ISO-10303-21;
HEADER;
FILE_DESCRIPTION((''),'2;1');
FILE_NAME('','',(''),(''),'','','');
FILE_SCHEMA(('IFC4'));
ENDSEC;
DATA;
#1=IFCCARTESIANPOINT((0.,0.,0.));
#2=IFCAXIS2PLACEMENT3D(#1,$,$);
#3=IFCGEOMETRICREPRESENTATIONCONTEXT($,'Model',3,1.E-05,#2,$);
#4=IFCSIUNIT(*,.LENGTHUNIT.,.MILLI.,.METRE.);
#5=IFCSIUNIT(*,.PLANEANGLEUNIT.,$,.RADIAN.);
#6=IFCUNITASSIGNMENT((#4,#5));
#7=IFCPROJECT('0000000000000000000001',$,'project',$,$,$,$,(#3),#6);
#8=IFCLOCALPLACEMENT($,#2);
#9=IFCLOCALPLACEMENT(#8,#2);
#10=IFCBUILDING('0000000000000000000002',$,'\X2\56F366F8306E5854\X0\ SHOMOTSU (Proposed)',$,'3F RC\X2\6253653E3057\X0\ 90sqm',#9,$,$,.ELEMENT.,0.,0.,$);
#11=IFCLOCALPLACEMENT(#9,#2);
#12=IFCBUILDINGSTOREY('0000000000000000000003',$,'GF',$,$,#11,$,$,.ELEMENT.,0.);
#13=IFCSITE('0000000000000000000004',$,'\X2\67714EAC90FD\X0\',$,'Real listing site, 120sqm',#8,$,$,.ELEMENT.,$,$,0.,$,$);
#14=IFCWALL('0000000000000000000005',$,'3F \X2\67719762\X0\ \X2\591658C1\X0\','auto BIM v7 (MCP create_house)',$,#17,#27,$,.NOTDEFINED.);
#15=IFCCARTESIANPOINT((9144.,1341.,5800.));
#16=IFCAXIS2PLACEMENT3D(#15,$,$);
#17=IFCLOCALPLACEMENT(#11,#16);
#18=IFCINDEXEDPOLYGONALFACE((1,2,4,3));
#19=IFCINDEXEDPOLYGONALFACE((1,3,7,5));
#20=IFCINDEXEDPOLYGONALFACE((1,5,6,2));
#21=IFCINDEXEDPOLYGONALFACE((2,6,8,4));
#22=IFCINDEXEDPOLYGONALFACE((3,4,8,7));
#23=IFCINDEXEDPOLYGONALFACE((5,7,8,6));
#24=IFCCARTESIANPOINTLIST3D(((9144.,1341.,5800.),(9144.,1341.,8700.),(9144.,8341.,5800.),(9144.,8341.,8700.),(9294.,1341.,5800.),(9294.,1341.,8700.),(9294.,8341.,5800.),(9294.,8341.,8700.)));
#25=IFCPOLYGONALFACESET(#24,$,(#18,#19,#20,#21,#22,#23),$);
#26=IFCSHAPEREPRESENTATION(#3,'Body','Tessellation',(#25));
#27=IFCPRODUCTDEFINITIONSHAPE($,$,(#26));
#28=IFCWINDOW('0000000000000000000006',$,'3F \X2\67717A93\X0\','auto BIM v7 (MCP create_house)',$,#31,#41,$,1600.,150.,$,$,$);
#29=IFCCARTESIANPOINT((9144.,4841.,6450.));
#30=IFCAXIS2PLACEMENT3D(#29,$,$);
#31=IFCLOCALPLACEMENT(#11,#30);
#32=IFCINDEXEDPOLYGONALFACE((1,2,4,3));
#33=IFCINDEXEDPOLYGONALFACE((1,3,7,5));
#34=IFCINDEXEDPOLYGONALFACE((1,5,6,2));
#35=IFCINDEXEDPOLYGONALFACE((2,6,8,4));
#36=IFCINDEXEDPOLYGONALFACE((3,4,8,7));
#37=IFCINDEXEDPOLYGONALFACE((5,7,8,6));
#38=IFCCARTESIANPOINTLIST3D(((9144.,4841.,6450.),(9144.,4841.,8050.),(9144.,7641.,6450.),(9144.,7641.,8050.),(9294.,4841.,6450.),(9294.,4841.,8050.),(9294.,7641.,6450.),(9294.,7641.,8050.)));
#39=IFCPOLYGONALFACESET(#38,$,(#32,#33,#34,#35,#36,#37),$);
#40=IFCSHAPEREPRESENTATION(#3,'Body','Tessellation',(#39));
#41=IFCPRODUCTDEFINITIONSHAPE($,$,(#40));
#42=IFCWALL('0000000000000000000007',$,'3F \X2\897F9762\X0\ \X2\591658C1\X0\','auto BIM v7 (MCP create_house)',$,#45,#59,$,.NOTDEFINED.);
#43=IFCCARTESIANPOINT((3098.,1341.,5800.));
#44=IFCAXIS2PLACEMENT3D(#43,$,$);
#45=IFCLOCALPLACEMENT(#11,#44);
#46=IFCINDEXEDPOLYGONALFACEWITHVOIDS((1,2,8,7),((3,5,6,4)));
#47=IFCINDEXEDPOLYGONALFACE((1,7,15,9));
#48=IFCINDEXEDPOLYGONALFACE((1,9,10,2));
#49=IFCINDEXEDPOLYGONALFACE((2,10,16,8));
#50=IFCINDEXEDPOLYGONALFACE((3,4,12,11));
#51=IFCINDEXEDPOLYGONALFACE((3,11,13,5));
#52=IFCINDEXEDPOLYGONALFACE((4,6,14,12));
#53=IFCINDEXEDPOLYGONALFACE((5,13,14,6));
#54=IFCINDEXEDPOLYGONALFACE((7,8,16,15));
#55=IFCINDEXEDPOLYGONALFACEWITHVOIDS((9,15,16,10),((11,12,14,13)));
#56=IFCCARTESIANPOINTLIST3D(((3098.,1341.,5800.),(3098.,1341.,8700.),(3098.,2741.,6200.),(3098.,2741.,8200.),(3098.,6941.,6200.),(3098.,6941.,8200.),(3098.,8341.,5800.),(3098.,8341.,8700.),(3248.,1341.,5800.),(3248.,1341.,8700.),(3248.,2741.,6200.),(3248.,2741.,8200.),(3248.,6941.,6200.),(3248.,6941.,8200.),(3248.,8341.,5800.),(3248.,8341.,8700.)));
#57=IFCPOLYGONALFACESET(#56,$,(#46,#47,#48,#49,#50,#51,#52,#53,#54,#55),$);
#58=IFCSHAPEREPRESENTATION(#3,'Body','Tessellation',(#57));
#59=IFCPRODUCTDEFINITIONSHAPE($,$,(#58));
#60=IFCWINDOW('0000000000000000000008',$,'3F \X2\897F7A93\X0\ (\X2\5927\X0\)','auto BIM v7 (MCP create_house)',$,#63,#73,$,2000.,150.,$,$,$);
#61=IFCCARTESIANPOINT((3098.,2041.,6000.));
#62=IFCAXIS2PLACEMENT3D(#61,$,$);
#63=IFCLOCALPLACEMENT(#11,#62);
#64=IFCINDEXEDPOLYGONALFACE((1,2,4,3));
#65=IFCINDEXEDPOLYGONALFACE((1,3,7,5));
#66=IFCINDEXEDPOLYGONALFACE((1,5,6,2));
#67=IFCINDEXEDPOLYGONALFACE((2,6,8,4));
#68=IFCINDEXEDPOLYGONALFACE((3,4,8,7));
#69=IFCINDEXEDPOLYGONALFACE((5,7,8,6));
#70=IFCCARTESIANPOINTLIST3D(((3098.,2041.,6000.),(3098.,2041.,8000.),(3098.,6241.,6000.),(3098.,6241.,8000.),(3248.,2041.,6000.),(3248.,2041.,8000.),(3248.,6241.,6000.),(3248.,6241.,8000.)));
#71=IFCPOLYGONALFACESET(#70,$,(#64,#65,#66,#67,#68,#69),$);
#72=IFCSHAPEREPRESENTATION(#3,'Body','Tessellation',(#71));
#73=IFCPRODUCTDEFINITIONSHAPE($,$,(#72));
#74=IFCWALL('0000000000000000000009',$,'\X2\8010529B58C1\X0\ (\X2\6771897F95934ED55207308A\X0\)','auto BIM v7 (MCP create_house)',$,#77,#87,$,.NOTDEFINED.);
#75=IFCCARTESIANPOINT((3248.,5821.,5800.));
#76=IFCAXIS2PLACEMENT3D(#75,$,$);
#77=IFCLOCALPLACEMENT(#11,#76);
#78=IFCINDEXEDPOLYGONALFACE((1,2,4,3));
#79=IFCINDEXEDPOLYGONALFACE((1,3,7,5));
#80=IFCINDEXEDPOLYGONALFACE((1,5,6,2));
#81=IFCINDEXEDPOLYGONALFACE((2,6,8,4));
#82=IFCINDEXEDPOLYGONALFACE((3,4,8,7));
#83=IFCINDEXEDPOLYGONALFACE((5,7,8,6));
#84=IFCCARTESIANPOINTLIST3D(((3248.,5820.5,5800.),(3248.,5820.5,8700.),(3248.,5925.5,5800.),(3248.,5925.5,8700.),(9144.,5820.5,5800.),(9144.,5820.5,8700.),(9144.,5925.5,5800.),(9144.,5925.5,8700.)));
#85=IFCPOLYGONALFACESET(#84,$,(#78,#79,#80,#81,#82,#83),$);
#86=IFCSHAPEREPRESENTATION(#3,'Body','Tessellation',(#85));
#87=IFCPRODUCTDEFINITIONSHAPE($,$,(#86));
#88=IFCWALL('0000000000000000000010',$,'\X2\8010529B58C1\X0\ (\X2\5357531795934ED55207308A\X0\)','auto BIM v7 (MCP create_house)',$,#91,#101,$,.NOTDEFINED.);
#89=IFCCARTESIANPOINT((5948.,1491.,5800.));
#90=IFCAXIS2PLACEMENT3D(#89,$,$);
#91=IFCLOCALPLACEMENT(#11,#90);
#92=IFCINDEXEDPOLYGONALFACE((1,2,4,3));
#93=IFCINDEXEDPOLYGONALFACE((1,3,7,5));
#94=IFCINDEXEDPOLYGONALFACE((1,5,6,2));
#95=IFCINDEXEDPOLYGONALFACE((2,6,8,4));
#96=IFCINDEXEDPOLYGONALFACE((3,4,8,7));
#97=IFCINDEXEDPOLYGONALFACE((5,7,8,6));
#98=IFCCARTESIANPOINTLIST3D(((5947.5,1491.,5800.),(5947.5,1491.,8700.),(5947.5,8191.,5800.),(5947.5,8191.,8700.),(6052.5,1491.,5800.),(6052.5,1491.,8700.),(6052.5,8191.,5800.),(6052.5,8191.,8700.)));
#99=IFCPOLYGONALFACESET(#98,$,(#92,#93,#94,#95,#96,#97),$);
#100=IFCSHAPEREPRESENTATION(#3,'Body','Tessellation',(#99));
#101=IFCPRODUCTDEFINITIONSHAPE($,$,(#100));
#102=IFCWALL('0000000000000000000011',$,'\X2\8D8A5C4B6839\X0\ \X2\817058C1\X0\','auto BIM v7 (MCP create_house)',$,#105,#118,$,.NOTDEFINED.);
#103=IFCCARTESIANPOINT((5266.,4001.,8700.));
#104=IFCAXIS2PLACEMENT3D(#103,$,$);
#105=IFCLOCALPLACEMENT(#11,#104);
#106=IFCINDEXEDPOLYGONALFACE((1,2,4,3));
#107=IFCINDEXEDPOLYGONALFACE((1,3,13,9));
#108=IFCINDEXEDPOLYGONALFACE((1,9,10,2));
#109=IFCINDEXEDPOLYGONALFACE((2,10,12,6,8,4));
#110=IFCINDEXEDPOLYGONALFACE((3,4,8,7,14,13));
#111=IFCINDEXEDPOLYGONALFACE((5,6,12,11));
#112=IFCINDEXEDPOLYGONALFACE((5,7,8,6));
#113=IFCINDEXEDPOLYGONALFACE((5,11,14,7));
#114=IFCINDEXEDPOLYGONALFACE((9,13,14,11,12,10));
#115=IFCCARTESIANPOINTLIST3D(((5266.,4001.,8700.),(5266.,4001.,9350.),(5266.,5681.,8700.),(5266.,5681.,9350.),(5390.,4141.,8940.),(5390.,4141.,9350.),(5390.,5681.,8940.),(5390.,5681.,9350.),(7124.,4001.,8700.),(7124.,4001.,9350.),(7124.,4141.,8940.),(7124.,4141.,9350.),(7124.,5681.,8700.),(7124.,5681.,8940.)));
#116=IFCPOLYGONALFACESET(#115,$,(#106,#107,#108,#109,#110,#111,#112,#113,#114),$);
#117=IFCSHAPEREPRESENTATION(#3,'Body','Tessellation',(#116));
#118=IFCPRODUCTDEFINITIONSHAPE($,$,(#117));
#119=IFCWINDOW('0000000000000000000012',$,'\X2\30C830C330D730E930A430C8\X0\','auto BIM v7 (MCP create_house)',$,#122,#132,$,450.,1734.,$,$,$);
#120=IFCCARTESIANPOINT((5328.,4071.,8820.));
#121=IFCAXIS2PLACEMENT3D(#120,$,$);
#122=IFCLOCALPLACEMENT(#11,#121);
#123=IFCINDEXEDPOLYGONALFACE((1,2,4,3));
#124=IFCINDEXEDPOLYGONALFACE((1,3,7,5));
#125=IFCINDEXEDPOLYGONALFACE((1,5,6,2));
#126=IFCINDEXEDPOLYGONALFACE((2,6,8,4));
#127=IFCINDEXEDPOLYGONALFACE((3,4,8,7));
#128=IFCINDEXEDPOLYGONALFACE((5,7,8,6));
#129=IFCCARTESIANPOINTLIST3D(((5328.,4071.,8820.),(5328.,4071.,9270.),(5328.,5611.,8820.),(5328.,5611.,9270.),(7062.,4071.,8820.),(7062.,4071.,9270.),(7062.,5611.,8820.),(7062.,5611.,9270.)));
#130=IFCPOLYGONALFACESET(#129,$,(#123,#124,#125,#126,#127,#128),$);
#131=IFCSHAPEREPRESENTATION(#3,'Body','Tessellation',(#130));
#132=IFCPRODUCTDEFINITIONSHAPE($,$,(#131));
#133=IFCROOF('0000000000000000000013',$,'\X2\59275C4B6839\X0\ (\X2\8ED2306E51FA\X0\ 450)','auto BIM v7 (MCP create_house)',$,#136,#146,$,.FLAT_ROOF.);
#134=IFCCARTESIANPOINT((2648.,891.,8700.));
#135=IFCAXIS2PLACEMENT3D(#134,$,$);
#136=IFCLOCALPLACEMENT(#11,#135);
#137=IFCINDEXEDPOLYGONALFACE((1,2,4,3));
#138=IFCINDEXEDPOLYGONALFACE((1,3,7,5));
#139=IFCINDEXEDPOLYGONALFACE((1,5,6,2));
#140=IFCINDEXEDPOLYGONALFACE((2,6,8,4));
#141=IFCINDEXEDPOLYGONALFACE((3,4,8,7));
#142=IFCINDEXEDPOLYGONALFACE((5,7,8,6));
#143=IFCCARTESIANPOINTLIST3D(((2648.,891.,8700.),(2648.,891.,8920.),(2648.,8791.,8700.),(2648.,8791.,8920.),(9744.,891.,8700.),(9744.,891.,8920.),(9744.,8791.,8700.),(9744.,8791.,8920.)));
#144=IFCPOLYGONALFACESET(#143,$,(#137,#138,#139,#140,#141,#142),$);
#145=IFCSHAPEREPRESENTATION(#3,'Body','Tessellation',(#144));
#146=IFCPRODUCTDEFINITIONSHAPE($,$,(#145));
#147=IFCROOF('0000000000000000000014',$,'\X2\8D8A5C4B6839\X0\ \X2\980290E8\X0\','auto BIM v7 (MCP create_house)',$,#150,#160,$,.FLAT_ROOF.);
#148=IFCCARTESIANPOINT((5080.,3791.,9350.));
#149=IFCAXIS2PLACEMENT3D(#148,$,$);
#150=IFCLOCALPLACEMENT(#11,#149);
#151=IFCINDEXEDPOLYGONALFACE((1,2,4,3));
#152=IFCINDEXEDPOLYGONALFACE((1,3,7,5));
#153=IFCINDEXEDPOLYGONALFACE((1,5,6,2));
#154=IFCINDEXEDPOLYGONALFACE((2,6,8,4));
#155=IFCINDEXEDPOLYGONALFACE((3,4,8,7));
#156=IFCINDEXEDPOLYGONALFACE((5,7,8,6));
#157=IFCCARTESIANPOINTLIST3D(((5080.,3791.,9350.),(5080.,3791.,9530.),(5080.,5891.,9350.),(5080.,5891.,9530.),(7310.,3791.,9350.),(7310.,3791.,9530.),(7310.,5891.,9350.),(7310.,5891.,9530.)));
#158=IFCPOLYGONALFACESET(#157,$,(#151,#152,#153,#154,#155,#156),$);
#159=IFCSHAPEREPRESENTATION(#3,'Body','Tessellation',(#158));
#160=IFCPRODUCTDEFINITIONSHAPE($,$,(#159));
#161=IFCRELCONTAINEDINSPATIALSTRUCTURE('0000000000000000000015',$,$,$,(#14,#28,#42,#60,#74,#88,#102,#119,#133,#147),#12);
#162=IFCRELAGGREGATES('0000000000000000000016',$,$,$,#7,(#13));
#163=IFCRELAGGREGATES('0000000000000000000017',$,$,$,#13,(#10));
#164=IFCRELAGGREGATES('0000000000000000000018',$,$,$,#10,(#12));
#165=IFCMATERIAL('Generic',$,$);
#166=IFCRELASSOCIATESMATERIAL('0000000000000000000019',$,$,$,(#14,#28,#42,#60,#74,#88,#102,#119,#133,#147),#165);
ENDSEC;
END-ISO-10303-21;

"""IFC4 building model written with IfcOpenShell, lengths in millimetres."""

from ifc_helpers import new_model, si_unit, frame, frame_2d, origin, place, context, project, spatial, rectangle, extrude, material, element, fill, save


model = new_model("IFC4")

# Units and contexts
model_context = context("Model", 3, precision=1e-05, world=origin())
ifc_project = project(units=[si_unit("LENGTHUNIT", "METRE", prefix="MILLI"), si_unit("PLANEANGLEUNIT", "RADIAN")], contexts=[model_context])

# Site, building, storey
site_placement = place(None, origin())
site = spatial("IfcSite", under=ifc_project, at=site_placement, Name="東京都", ObjectType="Real listing site, 120sqm", CompositionType="ELEMENT", RefElevation=0.0)
building_placement = place(site_placement, origin())
building = spatial("IfcBuilding", under=site, at=building_placement, Name="図書の塔 SHOMOTSU (Proposed)", ObjectType="3F RC打放し 90sqm", CompositionType="ELEMENT", ElevationOfRefHeight=0.0, ElevationOfTerrain=0.0)
storey_placement = place(building_placement, origin())
storey = spatial("IfcBuildingStorey", under=building, at=storey_placement, Name="GF", CompositionType="ELEMENT", Elevation=0.0)

# Shared definitions
ifc_material = material(Name="Generic")

# Walls, openings, windows
wall_1_placement = place(storey_placement, frame((9144.0, 1341.0, 5800.0)))
wall_1 = element("IfcWall", 1, at=wall_1_placement, inside=storey, material=ifc_material, Name="3F 東面 外壁", Description="auto BIM v7 (MCP create_house)", PredefinedType="NOTDEFINED", context=model_context, shape_type="SweptSolid", body=[
    extrude(rectangle(XDim=150.0, YDim=7000.0, at=frame_2d((75.0, 3500.0))), frame((9144.0, 1341.0, 5800.0)), (0.0, 0.0, 1.0), 2900.0),
])
opening_1_placement = place(storey_placement, frame((9144.0, 4841.0, 6450.0)))
opening_1 = element("IfcOpeningElement", 2, at=opening_1_placement, cuts=wall_1, PredefinedType="NOTDEFINED", context=model_context, shape_type="SweptSolid", body=[
    extrude(rectangle(XDim=150.0, YDim=2800.0, at=frame_2d((75.0, 1400.0))), frame((9144.0, 4841.0, 6450.0)), (0.0, 0.0, 1.0), 1600.0),
])
window_1_placement = place(storey_placement, frame((9144.0, 4841.0, 6450.0)))
window_1 = element("IfcWindow", 3, at=window_1_placement, inside=storey, material=ifc_material, Name="3F 東窓", Description="auto BIM v7 (MCP create_house)", OverallHeight=1600.0, OverallWidth=150.0, context=model_context, shape_type="SweptSolid", body=[
    extrude(rectangle(XDim=150.0, YDim=2800.0, at=frame_2d((75.0, 1400.0))), frame((9144.0, 4841.0, 6450.0)), (0.0, 0.0, 1.0), 1600.0),
])
fill(opening_1, window_1)
wall_2_placement = place(storey_placement, frame((3098.0, 1341.0, 5800.0)))
wall_2 = element("IfcWall", 4, at=wall_2_placement, inside=storey, material=ifc_material, Name="3F 西面 外壁", Description="auto BIM v7 (MCP create_house)", PredefinedType="NOTDEFINED", context=model_context, shape_type="SweptSolid", body=[
    extrude(rectangle(XDim=150.0, YDim=7000.0, at=frame_2d((75.0, 3500.0))), frame((3098.0, 1341.0, 5800.0)), (0.0, 0.0, 1.0), 2900.0),
])
opening_2_placement = place(storey_placement, frame((3098.0, 2041.0, 6000.0)))
opening_2 = element("IfcOpeningElement", 5, at=opening_2_placement, cuts=wall_2, PredefinedType="NOTDEFINED", context=model_context, shape_type="SweptSolid", body=[
    extrude(rectangle(XDim=150.0, YDim=4200.0, at=frame_2d((75.0, 2100.0))), frame((3098.0, 2041.0, 6000.0)), (0.0, 0.0, 1.0), 2000.0),
])
window_2_placement = place(storey_placement, frame((3098.0, 2041.0, 6000.0)))
window_2 = element("IfcWindow", 6, at=window_2_placement, inside=storey, material=ifc_material, Name="3F 西窓 (大)", Description="auto BIM v7 (MCP create_house)", OverallHeight=2000.0, OverallWidth=150.0, context=model_context, shape_type="SweptSolid", body=[
    extrude(rectangle(XDim=150.0, YDim=4200.0, at=frame_2d((75.0, 2100.0))), frame((3098.0, 2041.0, 6000.0)), (0.0, 0.0, 1.0), 2000.0),
])
fill(opening_2, window_2)

# Walls
wall_3_placement = place(storey_placement, frame((3248.0, 5821.0, 5800.0)))
element("IfcWall", 7, at=wall_3_placement, inside=storey, material=ifc_material, Name="耐力壁 (東西間仕切り)", Description="auto BIM v7 (MCP create_house)", PredefinedType="NOTDEFINED", context=model_context, shape_type="SweptSolid", body=[
    extrude(rectangle(XDim=5896.0, YDim=105.0, at=frame_2d((2948.0, 52.0))), frame((3248.0, 5821.0, 5800.0)), (0.0, 0.0, 1.0), 2900.0),
])
wall_4_placement = place(storey_placement, frame((5948.0, 1491.0, 5800.0)))
element("IfcWall", 8, at=wall_4_placement, inside=storey, material=ifc_material, Name="耐力壁 (南北間仕切り)", Description="auto BIM v7 (MCP create_house)", PredefinedType="NOTDEFINED", context=model_context, shape_type="SweptSolid", body=[
    extrude(rectangle(XDim=105.0, YDim=6700.0, at=frame_2d((52.0, 3350.0))), frame((5948.0, 1491.0, 5800.0)), (0.0, 0.0, 1.0), 2900.0),
])

# Wall, opening, window
wall_5_placement = place(storey_placement, frame((5266.0, 4001.0, 8700.0)))
wall_5 = element("IfcWall", 9, at=wall_5_placement, inside=storey, material=ifc_material, Name="越屋根 腰壁", Description="auto BIM v7 (MCP create_house)", PredefinedType="NOTDEFINED", context=model_context, shape_type="SweptSolid", body=[
    extrude(rectangle(XDim=1858.0, YDim=1680.0, at=frame_2d((929.0, 840.0))), frame((5266.0, 4001.0, 8700.0)), (0.0, 0.0, 1.0), 650.0),
])
opening_3_placement = place(storey_placement, frame((5328.0, 4071.0, 8820.0)))
opening_3 = element("IfcOpeningElement", 10, at=opening_3_placement, cuts=wall_5, PredefinedType="NOTDEFINED", context=model_context, shape_type="SweptSolid", body=[
    extrude(rectangle(XDim=1734.0, YDim=1540.0, at=frame_2d((867.0, 770.0))), frame((5328.0, 4071.0, 8820.0)), (0.0, 0.0, 1.0), 450.0),
])
window_3_placement = place(storey_placement, frame((5328.0, 4071.0, 8820.0)))
window_3 = element("IfcWindow", 11, at=window_3_placement, inside=storey, material=ifc_material, Name="トップライト", Description="auto BIM v7 (MCP create_house)", OverallHeight=450.0, OverallWidth=1734.0, context=model_context, shape_type="SweptSolid", body=[
    extrude(rectangle(XDim=1734.0, YDim=1540.0, at=frame_2d((867.0, 770.0))), frame((5328.0, 4071.0, 8820.0)), (0.0, 0.0, 1.0), 450.0),
])
fill(opening_3, window_3)

# Roofs
roof_1_placement = place(storey_placement, frame((2648.0, 891.0, 8700.0)))
element("IfcRoof", 12, at=roof_1_placement, inside=storey, material=ifc_material, Name="大屋根 (軒の出 450)", Description="auto BIM v7 (MCP create_house)", PredefinedType="FLAT_ROOF", context=model_context, shape_type="SweptSolid", body=[
    extrude(rectangle(XDim=7096.0, YDim=7900.0, at=frame_2d((3548.0, 3950.0))), frame((2648.0, 891.0, 8700.0)), (0.0, 0.0, 1.0), 220.0),
])
roof_2_placement = place(storey_placement, frame((5080.0, 3791.0, 9350.0)))
element("IfcRoof", 13, at=roof_2_placement, inside=storey, material=ifc_material, Name="越屋根 頂部", Description="auto BIM v7 (MCP create_house)", PredefinedType="FLAT_ROOF", context=model_context, shape_type="SweptSolid", body=[
    extrude(rectangle(XDim=2230.0, YDim=2100.0, at=frame_2d((1115.0, 1050.0))), frame((5080.0, 3791.0, 9350.0)), (0.0, 0.0, 1.0), 180.0),
])

save(model, "model.ifc")
